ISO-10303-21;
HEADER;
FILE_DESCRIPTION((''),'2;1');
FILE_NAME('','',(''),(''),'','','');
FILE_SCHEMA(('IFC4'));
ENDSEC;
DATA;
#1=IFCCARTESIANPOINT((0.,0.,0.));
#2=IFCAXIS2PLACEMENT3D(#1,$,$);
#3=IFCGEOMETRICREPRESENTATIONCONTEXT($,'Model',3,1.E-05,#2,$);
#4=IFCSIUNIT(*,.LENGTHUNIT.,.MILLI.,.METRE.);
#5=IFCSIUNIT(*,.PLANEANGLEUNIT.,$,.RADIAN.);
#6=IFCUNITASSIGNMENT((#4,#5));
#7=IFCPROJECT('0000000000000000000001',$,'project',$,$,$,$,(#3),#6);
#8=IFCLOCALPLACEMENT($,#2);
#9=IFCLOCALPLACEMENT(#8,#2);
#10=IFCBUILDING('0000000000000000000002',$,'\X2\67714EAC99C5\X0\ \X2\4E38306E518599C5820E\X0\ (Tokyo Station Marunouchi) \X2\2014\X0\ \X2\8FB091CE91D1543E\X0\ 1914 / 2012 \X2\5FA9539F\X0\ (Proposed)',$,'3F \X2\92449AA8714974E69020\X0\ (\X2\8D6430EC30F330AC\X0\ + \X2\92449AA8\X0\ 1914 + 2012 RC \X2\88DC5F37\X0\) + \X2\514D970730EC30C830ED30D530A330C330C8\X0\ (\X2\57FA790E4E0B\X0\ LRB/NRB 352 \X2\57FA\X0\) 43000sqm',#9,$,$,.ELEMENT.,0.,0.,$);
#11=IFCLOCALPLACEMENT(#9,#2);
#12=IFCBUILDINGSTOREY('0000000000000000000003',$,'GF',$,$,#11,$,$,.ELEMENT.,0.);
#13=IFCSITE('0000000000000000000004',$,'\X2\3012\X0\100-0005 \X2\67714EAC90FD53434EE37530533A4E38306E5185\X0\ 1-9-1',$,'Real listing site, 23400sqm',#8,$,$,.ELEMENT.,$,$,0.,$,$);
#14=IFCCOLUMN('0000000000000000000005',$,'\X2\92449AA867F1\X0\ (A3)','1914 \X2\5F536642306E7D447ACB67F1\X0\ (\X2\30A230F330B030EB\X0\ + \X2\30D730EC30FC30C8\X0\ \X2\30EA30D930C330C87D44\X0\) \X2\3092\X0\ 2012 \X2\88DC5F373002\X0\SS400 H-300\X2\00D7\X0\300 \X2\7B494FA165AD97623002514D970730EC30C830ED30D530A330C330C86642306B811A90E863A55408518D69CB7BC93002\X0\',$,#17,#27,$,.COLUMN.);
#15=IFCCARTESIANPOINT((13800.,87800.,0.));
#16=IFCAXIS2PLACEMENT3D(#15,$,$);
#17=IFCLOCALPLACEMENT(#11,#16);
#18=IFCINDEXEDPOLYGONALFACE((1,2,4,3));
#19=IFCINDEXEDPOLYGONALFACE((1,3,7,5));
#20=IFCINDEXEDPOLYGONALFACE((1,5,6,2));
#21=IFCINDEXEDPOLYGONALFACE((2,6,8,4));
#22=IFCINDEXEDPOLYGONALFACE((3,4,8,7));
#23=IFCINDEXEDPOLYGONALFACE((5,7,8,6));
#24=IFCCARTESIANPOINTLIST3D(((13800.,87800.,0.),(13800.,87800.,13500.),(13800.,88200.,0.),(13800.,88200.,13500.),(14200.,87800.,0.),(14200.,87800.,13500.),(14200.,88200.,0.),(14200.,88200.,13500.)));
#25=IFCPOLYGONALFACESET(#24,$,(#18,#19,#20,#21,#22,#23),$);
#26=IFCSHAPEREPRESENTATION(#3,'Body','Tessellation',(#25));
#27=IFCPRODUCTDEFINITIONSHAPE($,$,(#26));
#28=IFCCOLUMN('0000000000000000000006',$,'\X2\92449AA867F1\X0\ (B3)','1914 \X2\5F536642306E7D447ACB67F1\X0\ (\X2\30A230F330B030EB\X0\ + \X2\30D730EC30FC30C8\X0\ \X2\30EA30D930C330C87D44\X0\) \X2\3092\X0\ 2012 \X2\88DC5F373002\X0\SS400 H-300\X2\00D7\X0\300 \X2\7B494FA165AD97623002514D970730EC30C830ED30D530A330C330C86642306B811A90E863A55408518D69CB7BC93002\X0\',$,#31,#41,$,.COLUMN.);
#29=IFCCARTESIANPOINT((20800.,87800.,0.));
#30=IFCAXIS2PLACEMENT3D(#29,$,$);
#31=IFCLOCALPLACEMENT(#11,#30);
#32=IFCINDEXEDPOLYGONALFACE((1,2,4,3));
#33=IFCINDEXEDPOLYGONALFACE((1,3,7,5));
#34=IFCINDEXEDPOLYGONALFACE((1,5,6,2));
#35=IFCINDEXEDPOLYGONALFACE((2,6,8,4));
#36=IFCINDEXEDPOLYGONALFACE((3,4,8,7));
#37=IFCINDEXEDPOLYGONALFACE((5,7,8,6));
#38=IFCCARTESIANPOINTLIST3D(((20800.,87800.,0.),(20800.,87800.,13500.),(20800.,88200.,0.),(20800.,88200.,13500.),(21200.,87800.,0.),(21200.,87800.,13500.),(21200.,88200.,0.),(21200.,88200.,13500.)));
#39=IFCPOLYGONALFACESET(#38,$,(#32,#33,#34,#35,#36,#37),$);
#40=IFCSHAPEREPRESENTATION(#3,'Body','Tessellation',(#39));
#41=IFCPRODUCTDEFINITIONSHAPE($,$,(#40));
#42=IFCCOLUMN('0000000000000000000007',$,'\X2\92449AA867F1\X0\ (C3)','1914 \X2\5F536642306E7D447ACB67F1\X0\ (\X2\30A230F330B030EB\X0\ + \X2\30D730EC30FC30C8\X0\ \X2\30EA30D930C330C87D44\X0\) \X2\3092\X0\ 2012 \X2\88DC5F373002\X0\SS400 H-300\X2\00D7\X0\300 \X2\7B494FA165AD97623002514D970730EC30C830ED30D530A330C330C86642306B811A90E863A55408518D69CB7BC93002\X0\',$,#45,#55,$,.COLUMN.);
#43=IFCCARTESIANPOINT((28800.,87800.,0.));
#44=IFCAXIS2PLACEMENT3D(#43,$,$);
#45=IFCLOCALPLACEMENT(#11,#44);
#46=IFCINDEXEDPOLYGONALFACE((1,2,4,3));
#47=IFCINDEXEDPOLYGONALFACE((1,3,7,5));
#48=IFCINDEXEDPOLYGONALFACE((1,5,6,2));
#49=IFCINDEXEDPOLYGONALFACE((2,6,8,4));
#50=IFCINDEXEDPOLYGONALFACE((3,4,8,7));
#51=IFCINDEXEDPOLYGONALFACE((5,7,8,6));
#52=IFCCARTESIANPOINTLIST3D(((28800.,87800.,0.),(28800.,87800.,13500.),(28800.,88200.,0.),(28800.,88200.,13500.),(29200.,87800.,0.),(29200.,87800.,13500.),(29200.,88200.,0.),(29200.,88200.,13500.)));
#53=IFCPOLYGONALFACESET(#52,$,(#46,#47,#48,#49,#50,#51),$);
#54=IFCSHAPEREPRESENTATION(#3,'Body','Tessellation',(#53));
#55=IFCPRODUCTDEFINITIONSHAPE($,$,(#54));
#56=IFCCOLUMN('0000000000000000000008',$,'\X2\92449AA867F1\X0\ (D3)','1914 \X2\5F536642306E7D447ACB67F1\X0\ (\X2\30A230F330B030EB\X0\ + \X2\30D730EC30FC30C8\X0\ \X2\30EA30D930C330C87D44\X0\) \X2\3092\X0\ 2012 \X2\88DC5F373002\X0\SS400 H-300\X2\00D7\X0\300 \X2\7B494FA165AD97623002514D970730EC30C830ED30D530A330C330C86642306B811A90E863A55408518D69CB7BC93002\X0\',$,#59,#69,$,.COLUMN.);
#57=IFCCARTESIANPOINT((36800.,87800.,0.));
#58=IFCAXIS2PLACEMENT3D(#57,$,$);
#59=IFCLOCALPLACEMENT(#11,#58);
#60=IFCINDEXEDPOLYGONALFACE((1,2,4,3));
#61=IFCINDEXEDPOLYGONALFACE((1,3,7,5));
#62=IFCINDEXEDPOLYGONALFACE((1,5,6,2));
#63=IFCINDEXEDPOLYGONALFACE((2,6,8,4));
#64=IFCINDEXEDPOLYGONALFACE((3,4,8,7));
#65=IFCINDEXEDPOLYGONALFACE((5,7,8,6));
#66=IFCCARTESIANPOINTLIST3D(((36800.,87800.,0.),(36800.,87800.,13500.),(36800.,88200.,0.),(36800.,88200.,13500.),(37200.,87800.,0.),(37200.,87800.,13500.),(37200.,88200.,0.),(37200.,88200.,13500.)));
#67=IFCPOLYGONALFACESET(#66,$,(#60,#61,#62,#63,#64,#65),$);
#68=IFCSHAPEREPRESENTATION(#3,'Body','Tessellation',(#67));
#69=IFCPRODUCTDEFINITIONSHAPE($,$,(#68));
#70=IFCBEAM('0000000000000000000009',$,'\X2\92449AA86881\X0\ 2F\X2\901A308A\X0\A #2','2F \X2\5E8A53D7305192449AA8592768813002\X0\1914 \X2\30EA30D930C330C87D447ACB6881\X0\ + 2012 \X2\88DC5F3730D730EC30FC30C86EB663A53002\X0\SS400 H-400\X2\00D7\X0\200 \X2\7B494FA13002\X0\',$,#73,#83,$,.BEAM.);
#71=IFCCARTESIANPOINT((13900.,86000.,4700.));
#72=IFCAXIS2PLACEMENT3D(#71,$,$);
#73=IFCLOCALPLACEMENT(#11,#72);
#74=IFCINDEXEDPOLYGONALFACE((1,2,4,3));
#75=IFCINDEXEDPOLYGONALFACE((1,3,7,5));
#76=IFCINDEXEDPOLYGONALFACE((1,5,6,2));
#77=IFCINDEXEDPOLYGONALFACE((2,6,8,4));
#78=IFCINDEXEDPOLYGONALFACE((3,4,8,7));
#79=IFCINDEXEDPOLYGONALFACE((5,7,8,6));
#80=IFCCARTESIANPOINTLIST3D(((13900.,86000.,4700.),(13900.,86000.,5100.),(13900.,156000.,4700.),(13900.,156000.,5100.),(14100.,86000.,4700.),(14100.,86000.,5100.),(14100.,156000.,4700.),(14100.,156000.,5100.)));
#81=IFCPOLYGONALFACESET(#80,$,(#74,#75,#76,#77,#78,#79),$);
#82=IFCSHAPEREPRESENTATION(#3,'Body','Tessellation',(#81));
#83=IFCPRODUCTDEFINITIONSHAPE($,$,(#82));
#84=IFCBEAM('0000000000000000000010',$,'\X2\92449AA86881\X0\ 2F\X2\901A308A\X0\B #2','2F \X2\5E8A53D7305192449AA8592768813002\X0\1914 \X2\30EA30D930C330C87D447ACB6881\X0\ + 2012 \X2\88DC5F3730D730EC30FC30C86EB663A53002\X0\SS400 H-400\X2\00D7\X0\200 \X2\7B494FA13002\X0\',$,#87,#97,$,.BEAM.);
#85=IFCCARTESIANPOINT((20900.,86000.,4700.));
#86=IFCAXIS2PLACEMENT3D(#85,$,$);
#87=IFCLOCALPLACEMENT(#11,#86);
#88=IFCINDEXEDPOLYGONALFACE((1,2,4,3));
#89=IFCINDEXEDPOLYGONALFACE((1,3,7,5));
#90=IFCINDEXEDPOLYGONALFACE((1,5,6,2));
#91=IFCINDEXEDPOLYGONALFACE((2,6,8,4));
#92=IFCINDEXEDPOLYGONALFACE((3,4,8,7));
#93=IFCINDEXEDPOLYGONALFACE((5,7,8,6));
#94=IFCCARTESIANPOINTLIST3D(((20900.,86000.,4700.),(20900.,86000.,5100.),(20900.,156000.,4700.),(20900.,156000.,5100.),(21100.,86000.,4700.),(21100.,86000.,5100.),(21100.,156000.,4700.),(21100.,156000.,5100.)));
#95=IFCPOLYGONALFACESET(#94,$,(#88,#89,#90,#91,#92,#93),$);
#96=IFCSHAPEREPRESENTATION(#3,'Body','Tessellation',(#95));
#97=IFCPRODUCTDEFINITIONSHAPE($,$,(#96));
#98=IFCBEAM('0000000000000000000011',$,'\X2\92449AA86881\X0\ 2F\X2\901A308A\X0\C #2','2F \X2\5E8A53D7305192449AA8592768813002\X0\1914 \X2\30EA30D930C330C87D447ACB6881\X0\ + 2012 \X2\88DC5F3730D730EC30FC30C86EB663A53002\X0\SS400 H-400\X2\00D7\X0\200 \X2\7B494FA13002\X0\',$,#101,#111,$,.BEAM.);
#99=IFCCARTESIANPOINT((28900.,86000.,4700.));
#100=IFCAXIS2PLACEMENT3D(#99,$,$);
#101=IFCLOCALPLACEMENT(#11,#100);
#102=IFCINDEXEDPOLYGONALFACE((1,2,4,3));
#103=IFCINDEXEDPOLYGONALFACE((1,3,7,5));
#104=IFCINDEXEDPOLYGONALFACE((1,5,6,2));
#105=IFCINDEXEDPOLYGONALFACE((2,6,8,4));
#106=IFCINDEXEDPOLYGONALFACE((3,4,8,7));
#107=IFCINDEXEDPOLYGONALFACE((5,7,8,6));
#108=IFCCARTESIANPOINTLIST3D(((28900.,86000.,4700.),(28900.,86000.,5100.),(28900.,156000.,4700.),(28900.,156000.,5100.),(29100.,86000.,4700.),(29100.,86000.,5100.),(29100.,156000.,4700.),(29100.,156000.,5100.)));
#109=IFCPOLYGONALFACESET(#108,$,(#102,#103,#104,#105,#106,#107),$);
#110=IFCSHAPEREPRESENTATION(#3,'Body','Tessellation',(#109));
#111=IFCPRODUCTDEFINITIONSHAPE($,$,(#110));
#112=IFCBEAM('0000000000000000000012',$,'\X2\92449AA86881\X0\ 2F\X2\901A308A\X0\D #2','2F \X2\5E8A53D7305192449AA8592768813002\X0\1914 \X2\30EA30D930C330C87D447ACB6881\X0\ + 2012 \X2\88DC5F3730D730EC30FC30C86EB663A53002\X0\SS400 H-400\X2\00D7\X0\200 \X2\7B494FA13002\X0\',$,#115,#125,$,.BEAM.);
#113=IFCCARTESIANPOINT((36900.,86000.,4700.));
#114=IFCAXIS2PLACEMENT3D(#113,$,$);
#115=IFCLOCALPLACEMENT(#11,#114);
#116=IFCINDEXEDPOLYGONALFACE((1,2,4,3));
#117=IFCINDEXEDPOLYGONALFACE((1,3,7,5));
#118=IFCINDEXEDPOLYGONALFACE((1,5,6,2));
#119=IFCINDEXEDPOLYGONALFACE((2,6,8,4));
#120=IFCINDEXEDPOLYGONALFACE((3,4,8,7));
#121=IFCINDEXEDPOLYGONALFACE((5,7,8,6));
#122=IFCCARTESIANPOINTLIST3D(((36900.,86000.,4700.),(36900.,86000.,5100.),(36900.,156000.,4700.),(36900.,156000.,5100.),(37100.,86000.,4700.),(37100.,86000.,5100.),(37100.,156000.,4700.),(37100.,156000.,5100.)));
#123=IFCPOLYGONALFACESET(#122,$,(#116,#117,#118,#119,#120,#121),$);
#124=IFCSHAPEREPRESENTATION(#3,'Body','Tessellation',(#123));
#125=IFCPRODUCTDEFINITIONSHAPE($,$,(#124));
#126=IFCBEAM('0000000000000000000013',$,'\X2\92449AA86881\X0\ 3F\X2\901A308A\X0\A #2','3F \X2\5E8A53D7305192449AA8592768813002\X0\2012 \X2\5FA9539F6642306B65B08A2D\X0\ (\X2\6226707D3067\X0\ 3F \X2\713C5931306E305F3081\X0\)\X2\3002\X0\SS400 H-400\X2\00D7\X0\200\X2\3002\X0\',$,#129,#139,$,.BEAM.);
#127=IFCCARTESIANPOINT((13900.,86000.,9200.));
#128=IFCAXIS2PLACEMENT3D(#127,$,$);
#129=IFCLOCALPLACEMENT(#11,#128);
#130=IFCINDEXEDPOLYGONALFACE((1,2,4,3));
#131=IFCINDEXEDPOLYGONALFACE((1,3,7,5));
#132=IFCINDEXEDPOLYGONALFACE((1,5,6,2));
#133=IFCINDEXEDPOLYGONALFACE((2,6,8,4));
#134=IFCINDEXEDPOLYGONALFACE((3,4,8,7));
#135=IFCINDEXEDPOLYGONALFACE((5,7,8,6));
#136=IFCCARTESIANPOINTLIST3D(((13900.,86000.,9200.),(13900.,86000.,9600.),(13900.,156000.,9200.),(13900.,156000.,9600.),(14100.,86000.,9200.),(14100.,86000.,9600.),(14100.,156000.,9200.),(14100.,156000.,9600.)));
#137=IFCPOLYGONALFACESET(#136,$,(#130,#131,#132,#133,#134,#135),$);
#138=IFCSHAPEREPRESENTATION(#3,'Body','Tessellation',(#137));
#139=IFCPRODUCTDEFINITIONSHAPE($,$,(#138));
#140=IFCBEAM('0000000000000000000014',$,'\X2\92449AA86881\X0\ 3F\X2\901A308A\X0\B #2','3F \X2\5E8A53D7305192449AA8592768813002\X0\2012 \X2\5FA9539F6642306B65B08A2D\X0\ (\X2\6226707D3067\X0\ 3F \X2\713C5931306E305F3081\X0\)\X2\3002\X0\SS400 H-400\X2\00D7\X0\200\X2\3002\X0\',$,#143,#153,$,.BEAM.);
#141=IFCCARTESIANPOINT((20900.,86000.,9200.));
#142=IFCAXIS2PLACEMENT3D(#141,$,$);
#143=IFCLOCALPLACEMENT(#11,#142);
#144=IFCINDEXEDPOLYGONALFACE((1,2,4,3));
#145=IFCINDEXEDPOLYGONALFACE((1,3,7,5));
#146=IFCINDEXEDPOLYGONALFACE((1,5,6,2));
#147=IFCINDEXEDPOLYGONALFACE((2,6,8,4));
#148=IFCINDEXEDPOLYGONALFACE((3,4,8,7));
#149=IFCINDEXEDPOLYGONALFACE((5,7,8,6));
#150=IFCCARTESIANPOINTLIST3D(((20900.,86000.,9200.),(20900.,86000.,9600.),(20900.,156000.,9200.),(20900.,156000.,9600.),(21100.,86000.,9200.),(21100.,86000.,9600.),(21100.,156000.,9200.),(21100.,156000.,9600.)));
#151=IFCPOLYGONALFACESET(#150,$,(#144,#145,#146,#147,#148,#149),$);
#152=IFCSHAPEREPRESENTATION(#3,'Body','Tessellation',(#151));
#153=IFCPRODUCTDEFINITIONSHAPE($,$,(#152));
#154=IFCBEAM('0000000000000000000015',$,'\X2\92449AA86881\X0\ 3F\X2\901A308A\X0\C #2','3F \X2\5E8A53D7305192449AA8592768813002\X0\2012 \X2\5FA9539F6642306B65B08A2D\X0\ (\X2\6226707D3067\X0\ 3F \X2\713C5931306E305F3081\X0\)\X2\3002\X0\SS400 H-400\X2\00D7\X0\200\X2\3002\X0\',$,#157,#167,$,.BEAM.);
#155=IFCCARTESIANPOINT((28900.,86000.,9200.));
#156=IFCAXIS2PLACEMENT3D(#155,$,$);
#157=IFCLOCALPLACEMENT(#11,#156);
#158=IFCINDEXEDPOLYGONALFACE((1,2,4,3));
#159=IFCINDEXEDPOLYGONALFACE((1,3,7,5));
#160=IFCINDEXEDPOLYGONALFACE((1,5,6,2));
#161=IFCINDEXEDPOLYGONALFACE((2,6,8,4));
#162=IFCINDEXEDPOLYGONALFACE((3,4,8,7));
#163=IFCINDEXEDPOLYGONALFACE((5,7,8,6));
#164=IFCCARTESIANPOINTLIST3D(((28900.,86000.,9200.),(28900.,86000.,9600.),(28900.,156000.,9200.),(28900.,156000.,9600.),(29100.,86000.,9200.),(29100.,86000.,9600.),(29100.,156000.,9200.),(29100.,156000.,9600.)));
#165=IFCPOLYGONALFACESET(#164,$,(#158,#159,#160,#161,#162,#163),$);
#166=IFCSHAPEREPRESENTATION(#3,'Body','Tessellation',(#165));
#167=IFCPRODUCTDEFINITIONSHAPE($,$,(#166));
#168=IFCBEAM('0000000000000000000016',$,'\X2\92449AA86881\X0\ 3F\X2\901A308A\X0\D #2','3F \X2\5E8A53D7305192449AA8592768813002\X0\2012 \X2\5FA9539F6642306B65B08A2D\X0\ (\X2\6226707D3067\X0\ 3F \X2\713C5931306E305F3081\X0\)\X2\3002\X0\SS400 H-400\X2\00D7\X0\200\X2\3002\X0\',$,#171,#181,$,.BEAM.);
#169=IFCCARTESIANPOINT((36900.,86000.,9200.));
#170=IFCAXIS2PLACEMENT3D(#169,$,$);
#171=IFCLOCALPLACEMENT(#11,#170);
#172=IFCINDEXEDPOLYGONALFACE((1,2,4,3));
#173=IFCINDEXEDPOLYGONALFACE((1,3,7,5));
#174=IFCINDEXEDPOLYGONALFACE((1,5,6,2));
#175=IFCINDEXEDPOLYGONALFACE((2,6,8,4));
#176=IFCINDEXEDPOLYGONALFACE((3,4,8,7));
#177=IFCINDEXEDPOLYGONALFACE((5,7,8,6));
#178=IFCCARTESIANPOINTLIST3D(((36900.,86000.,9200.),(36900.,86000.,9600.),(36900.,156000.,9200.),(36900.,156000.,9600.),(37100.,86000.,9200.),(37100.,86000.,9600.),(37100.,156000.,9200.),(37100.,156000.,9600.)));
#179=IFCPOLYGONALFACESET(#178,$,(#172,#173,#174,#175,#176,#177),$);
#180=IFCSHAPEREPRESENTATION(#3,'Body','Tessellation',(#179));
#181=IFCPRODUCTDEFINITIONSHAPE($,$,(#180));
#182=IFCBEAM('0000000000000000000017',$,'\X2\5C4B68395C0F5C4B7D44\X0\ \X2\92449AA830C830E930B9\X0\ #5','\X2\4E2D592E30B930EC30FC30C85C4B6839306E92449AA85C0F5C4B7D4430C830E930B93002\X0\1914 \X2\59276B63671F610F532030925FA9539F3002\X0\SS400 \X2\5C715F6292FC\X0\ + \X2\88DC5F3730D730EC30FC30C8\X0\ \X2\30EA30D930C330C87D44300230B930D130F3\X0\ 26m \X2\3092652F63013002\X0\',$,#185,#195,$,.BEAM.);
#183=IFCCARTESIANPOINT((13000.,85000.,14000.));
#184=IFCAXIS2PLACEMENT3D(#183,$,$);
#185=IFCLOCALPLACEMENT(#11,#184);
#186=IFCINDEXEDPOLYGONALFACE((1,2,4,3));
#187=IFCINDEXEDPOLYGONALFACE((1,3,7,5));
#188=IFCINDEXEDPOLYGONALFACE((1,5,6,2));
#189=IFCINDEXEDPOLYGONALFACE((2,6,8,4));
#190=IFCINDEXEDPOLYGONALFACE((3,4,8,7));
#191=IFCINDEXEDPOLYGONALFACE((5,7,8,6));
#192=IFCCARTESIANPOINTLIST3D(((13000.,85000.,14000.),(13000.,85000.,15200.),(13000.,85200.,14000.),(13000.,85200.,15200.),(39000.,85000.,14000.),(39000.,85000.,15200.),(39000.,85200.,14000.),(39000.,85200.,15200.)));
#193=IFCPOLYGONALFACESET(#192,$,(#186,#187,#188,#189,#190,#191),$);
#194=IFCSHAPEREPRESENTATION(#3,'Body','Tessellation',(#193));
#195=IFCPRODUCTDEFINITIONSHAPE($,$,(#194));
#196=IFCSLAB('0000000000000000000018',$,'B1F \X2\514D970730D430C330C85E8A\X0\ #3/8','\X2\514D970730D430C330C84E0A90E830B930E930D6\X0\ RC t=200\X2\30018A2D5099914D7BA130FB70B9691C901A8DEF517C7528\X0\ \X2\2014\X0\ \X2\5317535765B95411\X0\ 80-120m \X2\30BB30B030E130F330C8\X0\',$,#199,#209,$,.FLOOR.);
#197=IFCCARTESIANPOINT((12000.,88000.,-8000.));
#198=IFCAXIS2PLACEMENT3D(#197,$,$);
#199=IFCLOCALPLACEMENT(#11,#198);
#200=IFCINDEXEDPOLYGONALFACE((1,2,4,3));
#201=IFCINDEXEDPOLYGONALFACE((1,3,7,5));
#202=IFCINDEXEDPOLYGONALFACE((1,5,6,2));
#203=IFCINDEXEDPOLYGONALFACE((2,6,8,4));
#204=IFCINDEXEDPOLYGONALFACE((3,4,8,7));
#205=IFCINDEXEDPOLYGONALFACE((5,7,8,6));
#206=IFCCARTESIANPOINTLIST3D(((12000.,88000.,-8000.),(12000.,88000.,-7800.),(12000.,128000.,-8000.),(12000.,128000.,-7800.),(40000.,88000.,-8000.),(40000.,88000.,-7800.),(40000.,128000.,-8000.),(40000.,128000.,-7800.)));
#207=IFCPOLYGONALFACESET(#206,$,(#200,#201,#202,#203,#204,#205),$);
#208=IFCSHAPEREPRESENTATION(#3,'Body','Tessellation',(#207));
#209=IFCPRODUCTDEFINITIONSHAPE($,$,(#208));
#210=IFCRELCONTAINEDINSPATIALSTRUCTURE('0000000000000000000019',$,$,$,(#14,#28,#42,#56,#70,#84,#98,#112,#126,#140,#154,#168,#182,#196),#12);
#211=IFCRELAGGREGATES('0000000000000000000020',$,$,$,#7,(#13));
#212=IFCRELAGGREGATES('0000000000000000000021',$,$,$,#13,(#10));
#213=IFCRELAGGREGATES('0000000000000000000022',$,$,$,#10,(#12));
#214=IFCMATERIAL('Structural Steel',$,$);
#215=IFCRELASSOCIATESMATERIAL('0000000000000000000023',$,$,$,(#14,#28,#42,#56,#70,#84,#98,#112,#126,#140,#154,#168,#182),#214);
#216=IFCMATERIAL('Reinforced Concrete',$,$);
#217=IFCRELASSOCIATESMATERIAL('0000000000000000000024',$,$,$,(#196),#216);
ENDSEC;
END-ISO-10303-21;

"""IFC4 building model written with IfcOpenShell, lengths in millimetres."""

from ifc_helpers import new_model, si_unit, frame, frame_2d, origin, place, context, project, spatial, rectangle, extrude, material, element, save


model = new_model("IFC4")

# Units and contexts
model_context = context("Model", 3, precision=1e-05, world=origin())
ifc_project = project(units=[si_unit("LENGTHUNIT", "METRE", prefix="MILLI"), si_unit("PLANEANGLEUNIT", "RADIAN")], contexts=[model_context])

# Site, building, storey
site_placement = place(None, origin())
site = spatial("IfcSite", under=ifc_project, at=site_placement, Name="〒100-0005 東京都千代田区丸の内 1-9-1", ObjectType="Real listing site, 23400sqm", CompositionType="ELEMENT", RefElevation=0.0)
building_placement = place(site_placement, origin())
building = spatial("IfcBuilding", under=site, at=building_placement, Name="東京駅 丸の内駅舎 (Tokyo Station Marunouchi) — 辰野金吾 1914 / 2012 復原 (Proposed)", ObjectType="3F 鉄骨煉瓦造 (赤レンガ + 鉄骨 1914 + 2012 RC 補強) + 免震レトロフィット (基礎下 LRB/NRB 352 基) 43000sqm", CompositionType="ELEMENT", ElevationOfRefHeight=0.0, ElevationOfTerrain=0.0)
storey_placement = place(building_placement, origin())
storey = spatial("IfcBuildingStorey", under=building, at=storey_placement, Name="GF", CompositionType="ELEMENT", Elevation=0.0)

# Columns
ifc_material_1 = material(Name="Structural Steel")
column_1_placement = place(storey_placement, frame((13800.0, 87800.0, 0.0)))
element("IfcColumn", 1, at=column_1_placement, inside=storey, material=ifc_material_1, Name="鉄骨柱 (A3)", Description="1914 当時の組立柱 (アングル + プレート リベット組) を 2012 補強。SS400 H-300×300 等価断面。免震レトロフィット時に脚部接合再構築。", PredefinedType="COLUMN", context=model_context, shape_type="SweptSolid", body=[
    extrude(rectangle(XDim=400.0, YDim=400.0, at=frame_2d((200.0, 200.0))), frame((13800.0, 87800.0, 0.0)), (0.0, 0.0, 1.0), 13500.0),
])
column_2_placement = place(storey_placement, frame((20800.0, 87800.0, 0.0)))
element("IfcColumn", 2, at=column_2_placement, inside=storey, material=ifc_material_1, Name="鉄骨柱 (B3)", Description="1914 当時の組立柱 (アングル + プレート リベット組) を 2012 補強。SS400 H-300×300 等価断面。免震レトロフィット時に脚部接合再構築。", PredefinedType="COLUMN", context=model_context, shape_type="SweptSolid", body=[
    extrude(rectangle(XDim=400.0, YDim=400.0, at=frame_2d((200.0, 200.0))), frame((20800.0, 87800.0, 0.0)), (0.0, 0.0, 1.0), 13500.0),
])
column_3_placement = place(storey_placement, frame((28800.0, 87800.0, 0.0)))
element("IfcColumn", 3, at=column_3_placement, inside=storey, material=ifc_material_1, Name="鉄骨柱 (C3)", Description="1914 当時の組立柱 (アングル + プレート リベット組) を 2012 補強。SS400 H-300×300 等価断面。免震レトロフィット時に脚部接合再構築。", PredefinedType="COLUMN", context=model_context, shape_type="SweptSolid", body=[
    extrude(rectangle(XDim=400.0, YDim=400.0, at=frame_2d((200.0, 200.0))), frame((28800.0, 87800.0, 0.0)), (0.0, 0.0, 1.0), 13500.0),
])
column_4_placement = place(storey_placement, frame((36800.0, 87800.0, 0.0)))
element("IfcColumn", 4, at=column_4_placement, inside=storey, material=ifc_material_1, Name="鉄骨柱 (D3)", Description="1914 当時の組立柱 (アングル + プレート リベット組) を 2012 補強。SS400 H-300×300 等価断面。免震レトロフィット時に脚部接合再構築。", PredefinedType="COLUMN", context=model_context, shape_type="SweptSolid", body=[
    extrude(rectangle(XDim=400.0, YDim=400.0, at=frame_2d((200.0, 200.0))), frame((36800.0, 87800.0, 0.0)), (0.0, 0.0, 1.0), 13500.0),
])

# Beams
beam_1_placement = place(storey_placement, frame((13900.0, 86000.0, 4700.0)))
element("IfcBeam", 5, at=beam_1_placement, inside=storey, material=ifc_material_1, Name="鉄骨梁 2F通りA #2", Description="2F 床受け鉄骨大梁。1914 リベット組立梁 + 2012 補強プレート溶接。SS400 H-400×200 等価。", PredefinedType="BEAM", context=model_context, shape_type="SweptSolid", body=[
    extrude(rectangle(XDim=200.0, YDim=70000.0, at=frame_2d((100.0, 35000.0))), frame((13900.0, 86000.0, 4700.0)), (0.0, 0.0, 1.0), 400.0),
])
beam_2_placement = place(storey_placement, frame((20900.0, 86000.0, 4700.0)))
element("IfcBeam", 6, at=beam_2_placement, inside=storey, material=ifc_material_1, Name="鉄骨梁 2F通りB #2", Description="2F 床受け鉄骨大梁。1914 リベット組立梁 + 2012 補強プレート溶接。SS400 H-400×200 等価。", PredefinedType="BEAM", context=model_context, shape_type="SweptSolid", body=[
    extrude(rectangle(XDim=200.0, YDim=70000.0, at=frame_2d((100.0, 35000.0))), frame((20900.0, 86000.0, 4700.0)), (0.0, 0.0, 1.0), 400.0),
])
beam_3_placement = place(storey_placement, frame((28900.0, 86000.0, 4700.0)))
element("IfcBeam", 7, at=beam_3_placement, inside=storey, material=ifc_material_1, Name="鉄骨梁 2F通りC #2", Description="2F 床受け鉄骨大梁。1914 リベット組立梁 + 2012 補強プレート溶接。SS400 H-400×200 等価。", PredefinedType="BEAM", context=model_context, shape_type="SweptSolid", body=[
    extrude(rectangle(XDim=200.0, YDim=70000.0, at=frame_2d((100.0, 35000.0))), frame((28900.0, 86000.0, 4700.0)), (0.0, 0.0, 1.0), 400.0),
])
beam_4_placement = place(storey_placement, frame((36900.0, 86000.0, 4700.0)))
element("IfcBeam", 8, at=beam_4_placement, inside=storey, material=ifc_material_1, Name="鉄骨梁 2F通りD #2", Description="2F 床受け鉄骨大梁。1914 リベット組立梁 + 2012 補強プレート溶接。SS400 H-400×200 等価。", PredefinedType="BEAM", context=model_context, shape_type="SweptSolid", body=[
    extrude(rectangle(XDim=200.0, YDim=70000.0, at=frame_2d((100.0, 35000.0))), frame((36900.0, 86000.0, 4700.0)), (0.0, 0.0, 1.0), 400.0),
])
beam_5_placement = place(storey_placement, frame((13900.0, 86000.0, 9200.0)))
element("IfcBeam", 9, at=beam_5_placement, inside=storey, material=ifc_material_1, Name="鉄骨梁 3F通りA #2", Description="3F 床受け鉄骨大梁。2012 復原時に新設 (戦災で 3F 焼失のため)。SS400 H-400×200。", PredefinedType="BEAM", context=model_context, shape_type="SweptSolid", body=[
    extrude(rectangle(XDim=200.0, YDim=70000.0, at=frame_2d((100.0, 35000.0))), frame((13900.0, 86000.0, 9200.0)), (0.0, 0.0, 1.0), 400.0),
])
beam_6_placement = place(storey_placement, frame((20900.0, 86000.0, 9200.0)))
element("IfcBeam", 10, at=beam_6_placement, inside=storey, material=ifc_material_1, Name="鉄骨梁 3F通りB #2", Description="3F 床受け鉄骨大梁。2012 復原時に新設 (戦災で 3F 焼失のため)。SS400 H-400×200。", PredefinedType="BEAM", context=model_context, shape_type="SweptSolid", body=[
    extrude(rectangle(XDim=200.0, YDim=70000.0, at=frame_2d((100.0, 35000.0))), frame((20900.0, 86000.0, 9200.0)), (0.0, 0.0, 1.0), 400.0),
])
beam_7_placement = place(storey_placement, frame((28900.0, 86000.0, 9200.0)))
element("IfcBeam", 11, at=beam_7_placement, inside=storey, material=ifc_material_1, Name="鉄骨梁 3F通りC #2", Description="3F 床受け鉄骨大梁。2012 復原時に新設 (戦災で 3F 焼失のため)。SS400 H-400×200。", PredefinedType="BEAM", context=model_context, shape_type="SweptSolid", body=[
    extrude(rectangle(XDim=200.0, YDim=70000.0, at=frame_2d((100.0, 35000.0))), frame((28900.0, 86000.0, 9200.0)), (0.0, 0.0, 1.0), 400.0),
])
beam_8_placement = place(storey_placement, frame((36900.0, 86000.0, 9200.0)))
element("IfcBeam", 12, at=beam_8_placement, inside=storey, material=ifc_material_1, Name="鉄骨梁 3F通りD #2", Description="3F 床受け鉄骨大梁。2012 復原時に新設 (戦災で 3F 焼失のため)。SS400 H-400×200。", PredefinedType="BEAM", context=model_context, shape_type="SweptSolid", body=[
    extrude(rectangle(XDim=200.0, YDim=70000.0, at=frame_2d((100.0, 35000.0))), frame((36900.0, 86000.0, 9200.0)), (0.0, 0.0, 1.0), 400.0),
])
beam_9_placement = place(storey_placement, frame((13000.0, 85000.0, 14000.0)))
element("IfcBeam", 13, at=beam_9_placement, inside=storey, material=ifc_material_1, Name="屋根小屋組 鉄骨トラス #5", Description="中央スレート屋根の鉄骨小屋組トラス。1914 大正期意匠を復原。SS400 山形鋼 + 補強プレート リベット組。スパン 26m を支持。", PredefinedType="BEAM", context=model_context, shape_type="SweptSolid", body=[
    extrude(rectangle(XDim=26000.0, YDim=200.0, at=frame_2d((13000.0, 100.0))), frame((13000.0, 85000.0, 14000.0)), (0.0, 0.0, 1.0), 1200.0),
])

# Slab
ifc_material_2 = material(Name="Reinforced Concrete")
slab_1_placement = place(storey_placement, frame((12000.0, 88000.0, -8000.0)))
element("IfcSlab", 14, at=slab_1_placement, inside=storey, material=ifc_material_2, Name="B1F 免震ピット床 #3/8", Description="免震ピット上部スラブ RC t=200、設備配管・点検通路兼用 — 北南方向 80-120m セグメント", PredefinedType="FLOOR", context=model_context, shape_type="SweptSolid", body=[
    extrude(rectangle(XDim=28000.0, YDim=40000.0, at=frame_2d((14000.0, 20000.0))), frame((12000.0, 88000.0, -8000.0)), (0.0, 0.0, 1.0), 200.0),
])

save(model, "model.ifc")
